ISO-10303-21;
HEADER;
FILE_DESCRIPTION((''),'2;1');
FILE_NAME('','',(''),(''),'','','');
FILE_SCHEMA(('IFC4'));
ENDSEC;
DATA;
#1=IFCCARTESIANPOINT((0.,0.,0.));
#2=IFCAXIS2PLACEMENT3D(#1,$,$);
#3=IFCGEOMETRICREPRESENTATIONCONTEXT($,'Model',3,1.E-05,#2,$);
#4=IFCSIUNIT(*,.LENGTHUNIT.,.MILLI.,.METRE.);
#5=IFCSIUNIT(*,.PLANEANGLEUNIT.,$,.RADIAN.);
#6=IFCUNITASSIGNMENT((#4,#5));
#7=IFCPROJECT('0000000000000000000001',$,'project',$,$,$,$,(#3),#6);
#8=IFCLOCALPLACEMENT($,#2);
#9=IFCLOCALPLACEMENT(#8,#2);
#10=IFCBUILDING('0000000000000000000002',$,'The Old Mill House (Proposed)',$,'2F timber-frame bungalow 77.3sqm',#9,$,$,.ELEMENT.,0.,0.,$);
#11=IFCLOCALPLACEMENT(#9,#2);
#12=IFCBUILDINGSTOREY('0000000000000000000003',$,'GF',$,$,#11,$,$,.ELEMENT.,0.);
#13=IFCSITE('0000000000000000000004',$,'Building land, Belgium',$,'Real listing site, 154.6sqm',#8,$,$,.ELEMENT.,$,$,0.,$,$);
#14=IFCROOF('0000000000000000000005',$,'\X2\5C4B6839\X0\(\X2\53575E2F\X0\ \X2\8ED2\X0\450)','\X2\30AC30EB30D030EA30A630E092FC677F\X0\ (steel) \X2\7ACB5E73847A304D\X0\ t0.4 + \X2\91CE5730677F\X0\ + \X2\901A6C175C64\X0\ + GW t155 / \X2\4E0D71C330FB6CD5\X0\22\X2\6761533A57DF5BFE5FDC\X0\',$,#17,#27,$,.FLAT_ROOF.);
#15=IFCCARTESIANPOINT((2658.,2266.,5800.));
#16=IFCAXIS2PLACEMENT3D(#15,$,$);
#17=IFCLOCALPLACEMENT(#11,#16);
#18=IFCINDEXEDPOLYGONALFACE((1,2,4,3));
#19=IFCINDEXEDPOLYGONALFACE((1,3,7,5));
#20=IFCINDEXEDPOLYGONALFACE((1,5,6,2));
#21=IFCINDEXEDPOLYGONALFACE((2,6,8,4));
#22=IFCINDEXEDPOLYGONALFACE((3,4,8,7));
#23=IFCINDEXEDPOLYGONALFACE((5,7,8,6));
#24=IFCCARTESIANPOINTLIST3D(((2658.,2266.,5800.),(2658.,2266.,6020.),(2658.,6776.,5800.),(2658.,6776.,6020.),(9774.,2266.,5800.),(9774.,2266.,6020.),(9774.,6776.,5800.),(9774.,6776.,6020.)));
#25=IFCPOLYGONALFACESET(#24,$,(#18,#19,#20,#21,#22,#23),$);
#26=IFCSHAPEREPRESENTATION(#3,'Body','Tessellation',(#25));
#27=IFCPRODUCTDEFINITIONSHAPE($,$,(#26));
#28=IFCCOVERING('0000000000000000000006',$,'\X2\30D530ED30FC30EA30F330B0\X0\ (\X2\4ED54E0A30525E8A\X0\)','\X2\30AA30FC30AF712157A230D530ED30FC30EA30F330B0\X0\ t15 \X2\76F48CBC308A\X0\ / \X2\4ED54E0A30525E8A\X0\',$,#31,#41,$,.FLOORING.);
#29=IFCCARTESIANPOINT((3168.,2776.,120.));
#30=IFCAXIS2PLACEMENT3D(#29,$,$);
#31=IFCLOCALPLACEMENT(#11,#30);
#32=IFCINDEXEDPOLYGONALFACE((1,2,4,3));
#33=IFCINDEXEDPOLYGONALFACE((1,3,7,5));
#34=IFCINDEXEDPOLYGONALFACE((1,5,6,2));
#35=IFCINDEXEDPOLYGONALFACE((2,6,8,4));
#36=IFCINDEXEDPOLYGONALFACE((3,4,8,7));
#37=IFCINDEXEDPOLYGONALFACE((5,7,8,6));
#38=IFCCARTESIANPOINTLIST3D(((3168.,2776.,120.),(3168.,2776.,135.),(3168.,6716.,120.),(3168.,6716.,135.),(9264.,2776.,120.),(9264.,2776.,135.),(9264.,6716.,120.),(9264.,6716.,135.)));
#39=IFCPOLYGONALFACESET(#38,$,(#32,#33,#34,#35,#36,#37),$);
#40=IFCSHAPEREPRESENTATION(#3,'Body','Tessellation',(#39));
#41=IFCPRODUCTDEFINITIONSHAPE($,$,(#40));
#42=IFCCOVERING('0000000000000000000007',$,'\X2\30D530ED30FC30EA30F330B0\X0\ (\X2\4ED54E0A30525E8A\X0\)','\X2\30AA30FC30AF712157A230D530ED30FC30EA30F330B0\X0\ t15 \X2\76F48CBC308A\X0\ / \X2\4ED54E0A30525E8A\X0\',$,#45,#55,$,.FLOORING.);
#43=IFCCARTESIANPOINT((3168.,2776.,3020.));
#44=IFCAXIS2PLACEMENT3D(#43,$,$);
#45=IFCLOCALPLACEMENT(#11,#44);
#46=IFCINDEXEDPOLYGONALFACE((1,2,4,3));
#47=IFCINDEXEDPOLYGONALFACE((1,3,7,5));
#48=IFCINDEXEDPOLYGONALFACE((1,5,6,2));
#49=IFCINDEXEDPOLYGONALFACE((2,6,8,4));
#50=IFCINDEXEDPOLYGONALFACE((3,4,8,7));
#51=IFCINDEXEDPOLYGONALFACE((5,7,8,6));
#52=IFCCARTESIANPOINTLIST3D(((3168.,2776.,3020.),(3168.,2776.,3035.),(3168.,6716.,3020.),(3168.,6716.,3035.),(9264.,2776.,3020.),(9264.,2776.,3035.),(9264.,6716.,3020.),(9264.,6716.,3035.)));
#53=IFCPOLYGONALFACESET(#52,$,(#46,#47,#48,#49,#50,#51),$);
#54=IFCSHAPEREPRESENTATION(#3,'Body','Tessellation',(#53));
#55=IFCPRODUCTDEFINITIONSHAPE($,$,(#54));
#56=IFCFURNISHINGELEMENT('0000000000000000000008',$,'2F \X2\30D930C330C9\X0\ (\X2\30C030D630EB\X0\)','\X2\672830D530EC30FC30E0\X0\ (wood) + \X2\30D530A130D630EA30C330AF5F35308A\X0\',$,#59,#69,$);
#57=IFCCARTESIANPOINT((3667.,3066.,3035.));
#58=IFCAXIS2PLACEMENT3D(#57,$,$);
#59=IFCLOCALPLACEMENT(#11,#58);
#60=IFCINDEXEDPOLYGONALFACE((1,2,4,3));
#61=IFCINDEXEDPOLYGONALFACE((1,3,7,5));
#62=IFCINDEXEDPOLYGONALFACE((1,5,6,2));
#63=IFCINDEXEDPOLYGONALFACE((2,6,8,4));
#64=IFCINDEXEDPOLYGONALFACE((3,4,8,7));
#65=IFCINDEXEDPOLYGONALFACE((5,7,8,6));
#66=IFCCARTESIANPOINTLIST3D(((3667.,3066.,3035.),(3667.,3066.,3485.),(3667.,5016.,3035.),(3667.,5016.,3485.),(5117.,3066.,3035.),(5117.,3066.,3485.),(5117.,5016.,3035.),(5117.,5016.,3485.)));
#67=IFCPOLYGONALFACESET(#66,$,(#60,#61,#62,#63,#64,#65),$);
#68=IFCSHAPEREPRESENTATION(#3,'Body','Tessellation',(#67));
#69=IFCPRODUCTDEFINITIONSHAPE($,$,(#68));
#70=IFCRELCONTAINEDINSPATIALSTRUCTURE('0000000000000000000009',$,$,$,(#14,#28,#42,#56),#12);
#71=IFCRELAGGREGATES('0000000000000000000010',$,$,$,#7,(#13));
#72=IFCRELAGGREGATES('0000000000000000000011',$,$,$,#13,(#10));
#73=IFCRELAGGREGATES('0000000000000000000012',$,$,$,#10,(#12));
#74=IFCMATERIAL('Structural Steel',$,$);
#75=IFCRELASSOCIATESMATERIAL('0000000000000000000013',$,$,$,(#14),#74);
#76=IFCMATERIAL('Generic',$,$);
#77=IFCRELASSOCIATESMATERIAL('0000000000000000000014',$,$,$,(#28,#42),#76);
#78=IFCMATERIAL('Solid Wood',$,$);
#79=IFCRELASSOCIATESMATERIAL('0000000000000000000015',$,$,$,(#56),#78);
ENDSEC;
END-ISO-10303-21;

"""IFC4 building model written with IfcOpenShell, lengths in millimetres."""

from ifc_helpers import new_model, si_unit, frame, frame_2d, origin, place, context, project, spatial, rectangle, extrude, material, element, save


model = new_model("IFC4")

# Units and contexts
model_context = context("Model", 3, precision=1e-05, world=origin())
ifc_project = project(units=[si_unit("LENGTHUNIT", "METRE", prefix="MILLI"), si_unit("PLANEANGLEUNIT", "RADIAN")], contexts=[model_context])

# Site, building, storey
site_placement = place(None, origin())
site = spatial("IfcSite", under=ifc_project, at=site_placement, Name="Building land, Belgium", ObjectType="Real listing site, 154.6sqm", CompositionType="ELEMENT", RefElevation=0.0)
building_placement = place(site_placement, origin())
building = spatial("IfcBuilding", under=site, at=building_placement, Name="The Old Mill House (Proposed)", ObjectType="2F timber-frame bungalow 77.3sqm", CompositionType="ELEMENT", ElevationOfRefHeight=0.0, ElevationOfTerrain=0.0)
storey_placement = place(building_placement, origin())
storey = spatial("IfcBuildingStorey", under=building, at=storey_placement, Name="GF", CompositionType="ELEMENT", Elevation=0.0)

# Shared definitions
ifc_material_1 = material(Name="Solid Wood")

# Roof
ifc_material_2 = material(Name="Structural Steel")
for number, where, name in (
    (1, (2658.0, 2266.0, 5800.0), "屋根(南帯 軒450)"),
):
    element("IfcRoof", number, at=place(storey_placement, frame(where)), inside=storey, material=ifc_material_2, Name=name, Description="ガルバリウム鋼板 (steel) 立平葺き t0.4 + 野地板 + 通気層 + GW t155 / 不燃・法22条区域対応", PredefinedType="FLAT_ROOF", context=model_context, shape_type="SweptSolid", body=[
        extrude(rectangle(XDim=7116.0, YDim=4510.0, at=frame_2d((3558.0, 2255.0))), frame((2658.0, 2266.0, 5800.0)), (0.0, 0.0, 1.0), 220.0),
    ])

# Coverings
ifc_material_3 = material(Name="Generic")
covering_1_placement = place(storey_placement, frame((3168.0, 2776.0, 120.0)))
element("IfcCovering", 2, at=covering_1_placement, inside=storey, material=ifc_material_3, Name="フローリング (仕上げ床)", Description="オーク無垢フローリング t15 直貼り / 仕上げ床", PredefinedType="FLOORING", context=model_context, shape_type="SweptSolid", body=[
    extrude(rectangle(XDim=6096.0, YDim=3940.0, at=frame_2d((3048.0, 1970.0))), frame((3168.0, 2776.0, 120.0)), (0.0, 0.0, 1.0), 15.0),
])
covering_2_placement = place(storey_placement, frame((3168.0, 2776.0, 3020.0)))
element("IfcCovering", 3, at=covering_2_placement, inside=storey, material=ifc_material_3, Name="フローリング (仕上げ床)", Description="オーク無垢フローリング t15 直貼り / 仕上げ床", PredefinedType="FLOORING", context=model_context, shape_type="SweptSolid", body=[
    extrude(rectangle(XDim=6096.0, YDim=3940.0, at=frame_2d((3048.0, 1970.0))), frame((3168.0, 2776.0, 3020.0)), (0.0, 0.0, 1.0), 15.0),
])

# Furnishing element
furnishing_placement = place(storey_placement, frame((3667.0, 3066.0, 3035.0)))
element("IfcFurnishingElement", 4, at=furnishing_placement, inside=storey, material=ifc_material_1, Name="2F ベッド (ダブル)", Description="木フレーム (wood) + ファブリック張り", context=model_context, shape_type="SweptSolid", body=[
    extrude(rectangle(XDim=1450.0, YDim=1950.0, at=frame_2d((725.0, 975.0))), frame((3667.0, 3066.0, 3035.0)), (0.0, 0.0, 1.0), 450.0),
])

save(model, "model.ifc")
